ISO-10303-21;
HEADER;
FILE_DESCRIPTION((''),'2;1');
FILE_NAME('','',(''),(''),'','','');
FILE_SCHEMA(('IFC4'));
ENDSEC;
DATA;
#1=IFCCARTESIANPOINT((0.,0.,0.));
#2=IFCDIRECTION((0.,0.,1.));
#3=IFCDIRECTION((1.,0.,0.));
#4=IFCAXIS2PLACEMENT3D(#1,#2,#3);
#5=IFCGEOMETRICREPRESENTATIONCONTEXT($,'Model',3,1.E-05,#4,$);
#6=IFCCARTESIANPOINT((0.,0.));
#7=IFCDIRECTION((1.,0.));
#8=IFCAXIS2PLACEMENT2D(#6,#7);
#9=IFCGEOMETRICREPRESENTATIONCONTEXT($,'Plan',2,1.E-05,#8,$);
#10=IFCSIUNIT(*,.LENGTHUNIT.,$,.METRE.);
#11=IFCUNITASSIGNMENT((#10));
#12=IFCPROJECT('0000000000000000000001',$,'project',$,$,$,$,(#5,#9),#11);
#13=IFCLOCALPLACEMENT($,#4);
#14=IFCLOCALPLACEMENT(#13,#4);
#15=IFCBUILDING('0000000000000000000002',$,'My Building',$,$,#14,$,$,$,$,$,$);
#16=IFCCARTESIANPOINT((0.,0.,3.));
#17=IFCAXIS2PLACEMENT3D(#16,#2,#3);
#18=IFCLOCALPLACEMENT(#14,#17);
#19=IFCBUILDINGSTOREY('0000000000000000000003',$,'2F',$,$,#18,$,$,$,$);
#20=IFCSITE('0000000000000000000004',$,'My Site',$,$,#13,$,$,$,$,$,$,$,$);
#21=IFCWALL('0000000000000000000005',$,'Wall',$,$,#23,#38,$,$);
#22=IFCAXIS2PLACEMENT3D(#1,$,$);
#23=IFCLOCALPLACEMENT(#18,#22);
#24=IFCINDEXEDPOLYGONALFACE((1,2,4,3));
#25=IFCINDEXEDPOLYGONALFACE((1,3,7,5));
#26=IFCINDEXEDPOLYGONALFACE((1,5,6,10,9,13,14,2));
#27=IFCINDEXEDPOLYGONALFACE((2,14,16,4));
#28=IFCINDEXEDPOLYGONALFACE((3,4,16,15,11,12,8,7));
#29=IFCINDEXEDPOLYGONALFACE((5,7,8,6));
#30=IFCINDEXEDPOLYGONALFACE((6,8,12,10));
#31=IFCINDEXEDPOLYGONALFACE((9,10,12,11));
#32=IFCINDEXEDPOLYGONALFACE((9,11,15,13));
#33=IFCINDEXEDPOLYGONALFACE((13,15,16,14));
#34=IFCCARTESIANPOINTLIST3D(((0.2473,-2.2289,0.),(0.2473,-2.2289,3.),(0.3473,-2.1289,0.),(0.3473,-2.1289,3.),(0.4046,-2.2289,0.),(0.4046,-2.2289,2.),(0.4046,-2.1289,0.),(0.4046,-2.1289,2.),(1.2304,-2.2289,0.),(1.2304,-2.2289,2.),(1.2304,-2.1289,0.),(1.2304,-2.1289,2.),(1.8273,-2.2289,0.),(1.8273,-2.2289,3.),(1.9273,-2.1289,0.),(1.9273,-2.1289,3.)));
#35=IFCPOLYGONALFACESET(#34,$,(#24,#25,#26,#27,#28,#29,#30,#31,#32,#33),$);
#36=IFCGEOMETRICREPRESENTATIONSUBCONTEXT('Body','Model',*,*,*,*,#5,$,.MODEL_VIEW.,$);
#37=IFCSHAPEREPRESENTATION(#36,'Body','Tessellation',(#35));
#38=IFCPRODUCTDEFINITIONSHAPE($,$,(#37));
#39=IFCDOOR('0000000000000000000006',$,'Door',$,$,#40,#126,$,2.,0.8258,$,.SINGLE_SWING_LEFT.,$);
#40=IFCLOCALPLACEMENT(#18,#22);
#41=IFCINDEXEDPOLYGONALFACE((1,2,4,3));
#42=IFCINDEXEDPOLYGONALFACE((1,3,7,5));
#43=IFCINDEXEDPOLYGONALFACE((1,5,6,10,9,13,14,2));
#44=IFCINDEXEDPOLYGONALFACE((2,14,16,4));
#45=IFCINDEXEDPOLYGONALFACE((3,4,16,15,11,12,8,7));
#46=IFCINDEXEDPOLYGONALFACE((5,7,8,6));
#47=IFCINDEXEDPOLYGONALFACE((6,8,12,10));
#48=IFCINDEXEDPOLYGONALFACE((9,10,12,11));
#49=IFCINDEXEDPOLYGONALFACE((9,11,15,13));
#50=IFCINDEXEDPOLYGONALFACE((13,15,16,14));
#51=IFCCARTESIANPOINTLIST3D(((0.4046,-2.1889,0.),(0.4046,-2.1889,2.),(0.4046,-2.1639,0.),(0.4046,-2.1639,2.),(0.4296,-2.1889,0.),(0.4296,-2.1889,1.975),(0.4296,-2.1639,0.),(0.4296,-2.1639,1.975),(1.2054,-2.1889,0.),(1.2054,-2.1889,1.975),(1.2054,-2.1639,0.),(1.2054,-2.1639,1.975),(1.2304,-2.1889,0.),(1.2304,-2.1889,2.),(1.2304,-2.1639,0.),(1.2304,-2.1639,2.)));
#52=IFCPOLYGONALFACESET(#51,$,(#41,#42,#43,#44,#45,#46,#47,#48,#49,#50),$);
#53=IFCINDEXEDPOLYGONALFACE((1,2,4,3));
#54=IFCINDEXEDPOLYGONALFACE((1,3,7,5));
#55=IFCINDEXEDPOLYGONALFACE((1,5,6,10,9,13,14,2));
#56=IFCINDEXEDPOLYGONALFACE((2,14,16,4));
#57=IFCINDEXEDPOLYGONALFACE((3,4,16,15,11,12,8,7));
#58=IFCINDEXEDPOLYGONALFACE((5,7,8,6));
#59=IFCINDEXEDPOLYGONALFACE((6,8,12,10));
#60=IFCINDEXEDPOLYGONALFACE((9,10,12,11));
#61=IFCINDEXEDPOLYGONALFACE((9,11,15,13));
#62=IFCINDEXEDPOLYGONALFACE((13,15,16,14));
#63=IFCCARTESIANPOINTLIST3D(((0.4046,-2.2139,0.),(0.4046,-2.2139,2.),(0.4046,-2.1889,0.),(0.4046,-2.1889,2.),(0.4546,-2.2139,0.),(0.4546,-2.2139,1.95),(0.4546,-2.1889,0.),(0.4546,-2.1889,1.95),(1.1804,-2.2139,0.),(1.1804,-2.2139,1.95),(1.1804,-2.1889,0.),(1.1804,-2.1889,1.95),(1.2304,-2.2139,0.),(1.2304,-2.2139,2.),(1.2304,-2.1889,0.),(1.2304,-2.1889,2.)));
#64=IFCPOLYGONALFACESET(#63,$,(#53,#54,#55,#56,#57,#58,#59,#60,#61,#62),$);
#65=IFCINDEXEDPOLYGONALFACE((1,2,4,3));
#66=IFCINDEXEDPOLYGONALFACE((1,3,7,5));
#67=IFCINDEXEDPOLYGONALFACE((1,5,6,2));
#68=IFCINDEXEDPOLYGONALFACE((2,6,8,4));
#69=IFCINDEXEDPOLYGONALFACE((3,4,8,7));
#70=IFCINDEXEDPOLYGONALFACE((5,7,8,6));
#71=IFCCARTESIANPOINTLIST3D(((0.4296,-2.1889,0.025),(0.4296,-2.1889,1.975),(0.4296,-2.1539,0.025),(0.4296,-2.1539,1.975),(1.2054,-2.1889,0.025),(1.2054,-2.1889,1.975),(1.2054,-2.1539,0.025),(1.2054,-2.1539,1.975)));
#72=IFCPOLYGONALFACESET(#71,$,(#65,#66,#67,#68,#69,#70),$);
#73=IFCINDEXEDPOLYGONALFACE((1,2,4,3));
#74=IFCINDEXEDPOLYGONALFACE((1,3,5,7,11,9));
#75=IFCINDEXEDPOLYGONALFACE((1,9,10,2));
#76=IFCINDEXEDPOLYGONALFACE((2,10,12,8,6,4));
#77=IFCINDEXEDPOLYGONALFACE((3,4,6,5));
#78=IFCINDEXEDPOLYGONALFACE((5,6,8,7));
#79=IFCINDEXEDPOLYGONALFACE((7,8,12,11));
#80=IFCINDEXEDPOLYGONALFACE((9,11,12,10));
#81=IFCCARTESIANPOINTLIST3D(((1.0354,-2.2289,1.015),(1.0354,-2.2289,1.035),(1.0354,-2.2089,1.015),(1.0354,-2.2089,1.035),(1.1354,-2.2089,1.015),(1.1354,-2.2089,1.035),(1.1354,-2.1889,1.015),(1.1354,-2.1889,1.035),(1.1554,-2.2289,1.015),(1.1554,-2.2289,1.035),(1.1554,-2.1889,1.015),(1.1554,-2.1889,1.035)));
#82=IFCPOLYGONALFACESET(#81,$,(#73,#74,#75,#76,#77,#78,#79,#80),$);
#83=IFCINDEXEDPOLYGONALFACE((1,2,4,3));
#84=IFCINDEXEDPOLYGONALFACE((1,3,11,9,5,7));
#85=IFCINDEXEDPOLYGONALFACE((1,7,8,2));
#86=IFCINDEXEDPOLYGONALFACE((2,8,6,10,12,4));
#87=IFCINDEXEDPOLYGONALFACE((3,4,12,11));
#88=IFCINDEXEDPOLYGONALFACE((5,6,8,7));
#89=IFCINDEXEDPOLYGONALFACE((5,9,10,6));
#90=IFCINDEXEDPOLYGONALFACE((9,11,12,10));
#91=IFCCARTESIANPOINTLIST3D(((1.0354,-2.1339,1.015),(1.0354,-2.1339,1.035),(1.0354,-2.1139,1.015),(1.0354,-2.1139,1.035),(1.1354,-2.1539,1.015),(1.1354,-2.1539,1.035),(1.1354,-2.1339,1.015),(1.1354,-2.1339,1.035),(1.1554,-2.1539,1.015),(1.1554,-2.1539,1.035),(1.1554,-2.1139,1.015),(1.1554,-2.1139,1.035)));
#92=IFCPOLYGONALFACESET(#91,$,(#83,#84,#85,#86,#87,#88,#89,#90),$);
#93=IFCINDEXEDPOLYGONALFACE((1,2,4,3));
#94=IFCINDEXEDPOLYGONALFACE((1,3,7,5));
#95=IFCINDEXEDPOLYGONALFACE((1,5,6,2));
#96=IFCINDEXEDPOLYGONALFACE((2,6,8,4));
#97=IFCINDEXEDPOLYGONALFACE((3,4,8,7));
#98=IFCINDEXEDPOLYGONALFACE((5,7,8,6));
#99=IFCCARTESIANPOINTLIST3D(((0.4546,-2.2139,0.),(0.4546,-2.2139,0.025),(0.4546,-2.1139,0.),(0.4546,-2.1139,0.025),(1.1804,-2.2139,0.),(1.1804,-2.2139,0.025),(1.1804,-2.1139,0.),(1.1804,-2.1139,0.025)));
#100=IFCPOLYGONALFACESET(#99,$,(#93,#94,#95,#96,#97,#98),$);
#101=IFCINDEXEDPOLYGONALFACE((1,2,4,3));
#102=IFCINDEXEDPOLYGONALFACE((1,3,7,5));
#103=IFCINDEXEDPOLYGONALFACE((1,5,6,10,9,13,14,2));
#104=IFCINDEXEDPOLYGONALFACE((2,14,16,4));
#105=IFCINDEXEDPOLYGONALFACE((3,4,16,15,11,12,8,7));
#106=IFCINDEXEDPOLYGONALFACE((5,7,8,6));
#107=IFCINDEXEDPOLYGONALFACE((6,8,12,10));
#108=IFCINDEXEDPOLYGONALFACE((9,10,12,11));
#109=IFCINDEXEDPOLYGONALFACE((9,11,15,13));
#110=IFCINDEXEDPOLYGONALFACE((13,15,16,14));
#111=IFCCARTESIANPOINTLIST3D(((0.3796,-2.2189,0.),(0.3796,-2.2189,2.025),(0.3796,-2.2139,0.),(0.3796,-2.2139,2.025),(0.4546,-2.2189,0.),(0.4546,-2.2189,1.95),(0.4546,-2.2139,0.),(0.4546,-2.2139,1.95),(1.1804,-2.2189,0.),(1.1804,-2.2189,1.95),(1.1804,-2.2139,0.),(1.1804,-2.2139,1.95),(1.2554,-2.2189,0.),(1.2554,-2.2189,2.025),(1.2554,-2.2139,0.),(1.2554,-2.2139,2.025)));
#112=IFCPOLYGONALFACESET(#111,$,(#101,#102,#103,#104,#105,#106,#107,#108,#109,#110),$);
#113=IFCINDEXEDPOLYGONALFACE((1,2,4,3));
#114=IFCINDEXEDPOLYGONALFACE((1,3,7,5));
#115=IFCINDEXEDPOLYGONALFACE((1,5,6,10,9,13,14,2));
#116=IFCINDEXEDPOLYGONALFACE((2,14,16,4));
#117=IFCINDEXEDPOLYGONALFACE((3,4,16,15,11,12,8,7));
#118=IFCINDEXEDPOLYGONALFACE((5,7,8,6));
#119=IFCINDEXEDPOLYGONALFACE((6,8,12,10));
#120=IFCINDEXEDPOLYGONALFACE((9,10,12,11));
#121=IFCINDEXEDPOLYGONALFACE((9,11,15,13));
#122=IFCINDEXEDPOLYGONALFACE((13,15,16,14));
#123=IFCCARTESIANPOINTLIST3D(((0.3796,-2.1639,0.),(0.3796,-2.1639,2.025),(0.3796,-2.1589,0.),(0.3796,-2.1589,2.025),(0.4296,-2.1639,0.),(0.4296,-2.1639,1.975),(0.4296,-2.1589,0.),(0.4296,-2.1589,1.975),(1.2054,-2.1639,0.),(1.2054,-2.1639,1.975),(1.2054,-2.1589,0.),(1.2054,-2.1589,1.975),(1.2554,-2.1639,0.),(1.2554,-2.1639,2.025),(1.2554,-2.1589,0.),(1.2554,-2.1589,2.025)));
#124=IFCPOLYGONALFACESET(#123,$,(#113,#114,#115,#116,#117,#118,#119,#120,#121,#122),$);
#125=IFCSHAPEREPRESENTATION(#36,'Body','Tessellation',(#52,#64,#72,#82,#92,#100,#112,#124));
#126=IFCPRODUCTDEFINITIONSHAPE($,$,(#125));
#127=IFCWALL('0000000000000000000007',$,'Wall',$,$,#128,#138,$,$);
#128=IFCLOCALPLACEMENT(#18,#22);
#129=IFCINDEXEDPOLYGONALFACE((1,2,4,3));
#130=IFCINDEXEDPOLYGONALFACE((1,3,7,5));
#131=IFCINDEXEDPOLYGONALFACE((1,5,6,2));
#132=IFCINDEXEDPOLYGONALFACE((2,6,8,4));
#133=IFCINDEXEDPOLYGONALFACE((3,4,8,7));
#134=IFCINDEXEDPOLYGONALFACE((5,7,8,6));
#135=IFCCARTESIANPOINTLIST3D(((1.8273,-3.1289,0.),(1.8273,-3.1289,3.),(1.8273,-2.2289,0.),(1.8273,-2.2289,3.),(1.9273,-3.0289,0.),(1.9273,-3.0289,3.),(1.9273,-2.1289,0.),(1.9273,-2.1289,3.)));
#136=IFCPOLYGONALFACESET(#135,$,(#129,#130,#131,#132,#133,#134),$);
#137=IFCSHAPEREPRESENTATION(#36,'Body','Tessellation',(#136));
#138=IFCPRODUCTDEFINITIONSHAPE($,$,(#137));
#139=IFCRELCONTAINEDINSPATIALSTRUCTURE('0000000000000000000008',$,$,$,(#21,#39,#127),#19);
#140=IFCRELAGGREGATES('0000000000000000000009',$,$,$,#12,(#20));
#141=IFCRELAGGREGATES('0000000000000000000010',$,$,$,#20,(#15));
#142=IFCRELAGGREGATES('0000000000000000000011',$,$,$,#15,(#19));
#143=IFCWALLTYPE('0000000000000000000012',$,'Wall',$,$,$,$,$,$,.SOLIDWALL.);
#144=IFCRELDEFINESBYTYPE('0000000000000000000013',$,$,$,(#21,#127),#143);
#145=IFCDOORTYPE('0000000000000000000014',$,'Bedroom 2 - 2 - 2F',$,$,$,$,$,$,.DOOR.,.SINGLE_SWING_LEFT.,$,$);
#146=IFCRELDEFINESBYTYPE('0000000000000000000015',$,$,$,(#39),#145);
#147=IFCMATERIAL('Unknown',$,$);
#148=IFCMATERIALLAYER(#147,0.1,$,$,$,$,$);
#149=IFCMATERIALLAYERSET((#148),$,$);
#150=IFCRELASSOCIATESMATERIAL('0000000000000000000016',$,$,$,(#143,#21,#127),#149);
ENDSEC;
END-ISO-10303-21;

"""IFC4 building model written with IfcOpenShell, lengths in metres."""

from ifc_helpers import new_model, entity, si_unit, frame, origin_with_axes, origin_2d_with_axis, place, context, subcontext, project, spatial, line, indexed_curve, outline, extrude, shape, source, transform, mapped, material, layer, layer_set, layer_usage, type_object, type_shapes, element, fill, save


model = new_model("IFC4")

# Units and contexts
model_context = context("Model", 3, precision=1e-05, world=origin_with_axes())
plan_context = context("Plan", 2, precision=1e-05, world=origin_2d_with_axis())
body_context_1 = subcontext(model_context, "Body", "Model", "MODEL_VIEW")
body_context_2 = subcontext(plan_context, "Body", "Plan", "PLAN_VIEW")
ifc_project = project(units=[si_unit("LENGTHUNIT", "METRE")], contexts=[model_context, plan_context])

# Site, building, storey
site_placement = place(None, origin_with_axes())
site = spatial("IfcSite", under=ifc_project, at=site_placement, Name="My Site")
building_placement = place(site_placement, origin_with_axes())
building = spatial("IfcBuilding", under=site, at=building_placement, Name="My Building")
storey_placement = place(building_placement, frame((0.0, 0.0, 3.0), z_axis=(0.0, 0.0, 1.0), x_axis=(1.0, 0.0, 0.0)))
storey = spatial("IfcBuildingStorey", under=building, at=storey_placement, Name="2F")

# Shared definitions
ifc_material = material(Name="Unknown")
ifc_layer = layer(ifc_material, 0.1)
ifc_layer_set = layer_set([ifc_layer])
wall_type = type_object("IfcWallType", Name="Wall", PredefinedType="SOLIDWALL", material=ifc_layer_set)

# Wall, opening, door
ifc_layer_usage_1 = layer_usage(ifc_layer_set, "AXIS2", "POSITIVE", 0.0)
wall_1_placement = place(storey_placement, frame((0.2473, -2.2289, 0.0), z_axis=(0.0, 0.0, 1.0), x_axis=(1.0, 0.0, 0.0)))
wall_1 = element("IfcWall", 1, at=wall_1_placement, inside=storey, type_object=wall_type, material=ifc_layer_usage_1, Name="Wall", context=body_context_1, shape_type="SweptSolid", body=[
    extrude(outline(indexed_curve([(0.0, 0.0), (0.1, 0.1), (1.68, 0.1), (1.58, 0.0)], segments=[line(1, 2, 3, 4, 1)])), origin_with_axes(), (0.0, 0.0, 1.0), 3.0),
])
shared_shape_1 = source(origin_with_axes(), body_context_1, "Body", "SweptSolid", [
    extrude(outline(indexed_curve([(0.0, 0.0), (0.8258, 0.0), (0.8258, 2.0), (0.0, 2.0)], segments=[line(1, 2, 3, 4, 1)])), frame((0.0, -0.6, 0.0), z_axis=(0.0, -1.0, 0.0), x_axis=(1.0, 0.0, 0.0)), (0.0, 0.0, -1.0), 1.2),
])
opening_1_placement = place(wall_1_placement, frame((0.1573, 0.015, 0.0), z_axis=(0.0, 0.0, 1.0), x_axis=(1.0, 0.0, 0.0)))
opening_1 = element("IfcOpeningElement", 2, at=opening_1_placement, cuts=wall_1, PredefinedType="OPENING", context=body_context_1, shape_type="MappedRepresentation", body=[
    mapped(shared_shape_1, transform((0.0, 0.0, 0.0), x_axis=(1.0, 0.0, 0.0), y_axis=(0.0, 1.0, 0.0), z_axis=(0.0, 0.0, 1.0), scale=1.0)),
])
door_type_1 = type_object("IfcDoorType", Name="Bedroom 2 - 2 - 2F", OperationType="SINGLE_SWING_LEFT", PredefinedType="DOOR")
shared_shape_2 = source(origin_with_axes(), body_context_1, "Body", "SweptSolid", [
    extrude(outline(indexed_curve([(0.0, 0.0), (0.0, 2.0), (0.8258, 2.0), (0.8258, 0.0), (0.8008, 0.0), (0.8008, 1.975), (0.025, 1.975), (0.025, 0.0)], segments=[line(1, 2, 3, 4, 5, 6, 7, 8, 1)])), frame((0.0, 0.025, 0.0), z_axis=(0.0, -1.0, 0.0), x_axis=(1.0, 0.0, 0.0)), (0.0, 0.0, -1.0), 0.025),
    extrude(outline(indexed_curve([(0.0, 0.0), (0.0, 2.0), (0.8258, 2.0), (0.8258, 0.0), (0.7758, 0.0), (0.7758, 1.95), (0.05, 1.95), (0.05, 0.0)], segments=[line(1, 2, 3, 4, 5, 6, 7, 8, 1)])), frame((0.0, 0.0, 0.0), z_axis=(0.0, -1.0, 0.0), x_axis=(1.0, 0.0, 0.0)), (0.0, 0.0, -1.0), 0.025),
    extrude(outline(indexed_curve([(0.0, 0.0), (0.7758, 0.0), (0.7758, 0.035), (0.0, 0.035)], segments=[line(1, 2, 3, 4, 1)])), frame((0.025, 0.025, 0.025), z_axis=(0.0, 0.0, 1.0), x_axis=(1.0, 0.0, 0.0)), (0.0, 0.0, 1.0), 1.95),
    extrude(outline(indexed_curve([(0.0, 0.0), (0.0, -0.04), (-0.12, -0.04), (-0.12, -0.02), (-0.02, -0.02), (-0.02, 0.0)], segments=[line(1, 2, 3, 4, 5, 6, 1)])), frame((0.7508, 0.025, 1.015), z_axis=(0.0, 0.0, 1.0), x_axis=(1.0, 0.0, 0.0)), (0.0, 0.0, 1.0), 0.02),
    extrude(outline(indexed_curve([(0.0, 0.0), (0.0, 0.04), (-0.12, 0.04), (-0.12, 0.02), (-0.02, 0.02), (-0.02, 0.0)], segments=[line(1, 2, 3, 4, 5, 6, 1)])), frame((0.7508, 0.06, 1.015), z_axis=(0.0, 0.0, 1.0), x_axis=(1.0, 0.0, 0.0)), (0.0, 0.0, 1.0), 0.02),
    extrude(outline(indexed_curve([(0.0, 0.0), (0.7258, 0.0), (0.7258, 0.1), (0.0, 0.1)], segments=[line(1, 2, 3, 4, 1)])), frame((0.05, 0.0, 0.0), z_axis=(0.0, 0.0, 1.0), x_axis=(1.0, 0.0, 0.0)), (0.0, 0.0, 1.0), 0.025),
    extrude(outline(indexed_curve([(0.0, 0.0), (0.0, 2.025), (0.8758, 2.025), (0.8758, 0.0), (0.8008, 0.0), (0.8008, 1.95), (0.075, 1.95), (0.075, 0.0)], segments=[line(1, 2, 3, 4, 5, 6, 7, 8, 1)])), frame((-0.025, -0.005, 0.0), z_axis=(0.0, -1.0, 0.0), x_axis=(1.0, 0.0, 0.0)), (0.0, 0.0, -1.0), 0.005),
    extrude(outline(indexed_curve([(0.0, 0.0), (0.0, 2.025), (0.8758, 2.025), (0.8758, 0.0), (0.8258, 0.0), (0.8258, 1.975), (0.05, 1.975), (0.05, 0.0)], segments=[line(1, 2, 3, 4, 5, 6, 7, 8, 1)])), frame((-0.025, 0.05, 0.0), z_axis=(0.0, -1.0, 0.0), x_axis=(1.0, 0.0, 0.0)), (0.0, 0.0, -1.0), 0.005),
])
shared_shape_3 = source(origin_with_axes(), body_context_2, "Body", "Curve2D", [
    entity("IfcIndexedPolyCurve", entity("IfcCartesianPointList2D", [[0.0, 0.0], [0.0, 0.05], [0.025, 0.05], [0.025, 0.025], [0.05, 0.025], [0.05, 0.0]]), [entity("IfcLineIndex", [1, 2, 3, 4, 5, 6, 1])]),
    entity("IfcIndexedPolyCurve", entity("IfcCartesianPointList2D", [[0.8258, 0.0], [0.8258, 0.05], [0.8008, 0.05], [0.8008, 0.025], [0.7758, 0.025], [0.7758, 0.0]]), [entity("IfcLineIndex", [1, 2, 3, 4, 5, 6, 1])]),
    entity("IfcTrimmedCurve", entity("IfcEllipse", entity("IfcAxis2Placement2D", entity("IfcCartesianPoint", [0.06, 0.05]), entity("IfcDirection", [1.0, 0.0])), 0.7408, 0.7758), [entity("IfcCartesianPoint", [0.8008, 0.05])], [entity("IfcCartesianPoint", [0.06, 0.8258])], True, "CARTESIAN"),
    entity("IfcIndexedPolyCurve", entity("IfcCartesianPointList2D", [[0.025, 0.05], [0.06, 0.05], [0.06, 0.8258], [0.025, 0.8258]]), [entity("IfcLineIndex", [1, 2, 3, 4, 1])]),
])
type_shapes(door_type_1, [shared_shape_2, shared_shape_3])
door_1_placement = place(opening_1_placement, frame((0.0, 0.0, 0.0), z_axis=(0.0, 0.0, 1.0), x_axis=(1.0, 0.0, 0.0)))
door_1 = element("IfcDoor", 3, at=door_1_placement, inside=storey, type_object=door_type_1, Name="Door", OperationType="SINGLE_SWING_LEFT", OverallHeight=2.0, OverallWidth=0.8258, shapes=[
    shape(body_context_1, "Body", "MappedRepresentation", [mapped(shared_shape_2, transform((0.0, 0.0, 0.0), x_axis=(1.0, 0.0, 0.0), y_axis=(0.0, 1.0, 0.0), z_axis=(0.0, 0.0, 1.0), scale=1.0))]),
    shape(body_context_2, "Body", "MappedRepresentation", [mapped(shared_shape_3, transform((0.0, 0.0, 0.0), x_axis=(1.0, 0.0, 0.0), y_axis=(0.0, 1.0, 0.0), z_axis=(0.0, 0.0, 1.0), scale=1.0))]),
])
fill(opening_1, door_1)

# Wall
ifc_layer_usage_2 = layer_usage(ifc_layer_set, "AXIS2", "POSITIVE", 0.0)
wall_2_placement = place(storey_placement, frame((1.8273, -2.2289, 0.0), z_axis=(0.0, 0.0, 1.0), x_axis=(0.0, -1.0, 0.0)))
element("IfcWall", 4, at=wall_2_placement, inside=storey, type_object=wall_type, material=ifc_layer_usage_2, Name="Wall", context=body_context_1, shape_type="SweptSolid", body=[
    extrude(outline(indexed_curve([(0.0, 0.0), (-0.1, 0.1), (0.8, 0.1), (0.9, 0.0)], segments=[line(1, 2, 3, 4, 1)])), origin_with_axes(), (0.0, 0.0, 1.0), 3.0),
])

save(model, "model.ifc")
